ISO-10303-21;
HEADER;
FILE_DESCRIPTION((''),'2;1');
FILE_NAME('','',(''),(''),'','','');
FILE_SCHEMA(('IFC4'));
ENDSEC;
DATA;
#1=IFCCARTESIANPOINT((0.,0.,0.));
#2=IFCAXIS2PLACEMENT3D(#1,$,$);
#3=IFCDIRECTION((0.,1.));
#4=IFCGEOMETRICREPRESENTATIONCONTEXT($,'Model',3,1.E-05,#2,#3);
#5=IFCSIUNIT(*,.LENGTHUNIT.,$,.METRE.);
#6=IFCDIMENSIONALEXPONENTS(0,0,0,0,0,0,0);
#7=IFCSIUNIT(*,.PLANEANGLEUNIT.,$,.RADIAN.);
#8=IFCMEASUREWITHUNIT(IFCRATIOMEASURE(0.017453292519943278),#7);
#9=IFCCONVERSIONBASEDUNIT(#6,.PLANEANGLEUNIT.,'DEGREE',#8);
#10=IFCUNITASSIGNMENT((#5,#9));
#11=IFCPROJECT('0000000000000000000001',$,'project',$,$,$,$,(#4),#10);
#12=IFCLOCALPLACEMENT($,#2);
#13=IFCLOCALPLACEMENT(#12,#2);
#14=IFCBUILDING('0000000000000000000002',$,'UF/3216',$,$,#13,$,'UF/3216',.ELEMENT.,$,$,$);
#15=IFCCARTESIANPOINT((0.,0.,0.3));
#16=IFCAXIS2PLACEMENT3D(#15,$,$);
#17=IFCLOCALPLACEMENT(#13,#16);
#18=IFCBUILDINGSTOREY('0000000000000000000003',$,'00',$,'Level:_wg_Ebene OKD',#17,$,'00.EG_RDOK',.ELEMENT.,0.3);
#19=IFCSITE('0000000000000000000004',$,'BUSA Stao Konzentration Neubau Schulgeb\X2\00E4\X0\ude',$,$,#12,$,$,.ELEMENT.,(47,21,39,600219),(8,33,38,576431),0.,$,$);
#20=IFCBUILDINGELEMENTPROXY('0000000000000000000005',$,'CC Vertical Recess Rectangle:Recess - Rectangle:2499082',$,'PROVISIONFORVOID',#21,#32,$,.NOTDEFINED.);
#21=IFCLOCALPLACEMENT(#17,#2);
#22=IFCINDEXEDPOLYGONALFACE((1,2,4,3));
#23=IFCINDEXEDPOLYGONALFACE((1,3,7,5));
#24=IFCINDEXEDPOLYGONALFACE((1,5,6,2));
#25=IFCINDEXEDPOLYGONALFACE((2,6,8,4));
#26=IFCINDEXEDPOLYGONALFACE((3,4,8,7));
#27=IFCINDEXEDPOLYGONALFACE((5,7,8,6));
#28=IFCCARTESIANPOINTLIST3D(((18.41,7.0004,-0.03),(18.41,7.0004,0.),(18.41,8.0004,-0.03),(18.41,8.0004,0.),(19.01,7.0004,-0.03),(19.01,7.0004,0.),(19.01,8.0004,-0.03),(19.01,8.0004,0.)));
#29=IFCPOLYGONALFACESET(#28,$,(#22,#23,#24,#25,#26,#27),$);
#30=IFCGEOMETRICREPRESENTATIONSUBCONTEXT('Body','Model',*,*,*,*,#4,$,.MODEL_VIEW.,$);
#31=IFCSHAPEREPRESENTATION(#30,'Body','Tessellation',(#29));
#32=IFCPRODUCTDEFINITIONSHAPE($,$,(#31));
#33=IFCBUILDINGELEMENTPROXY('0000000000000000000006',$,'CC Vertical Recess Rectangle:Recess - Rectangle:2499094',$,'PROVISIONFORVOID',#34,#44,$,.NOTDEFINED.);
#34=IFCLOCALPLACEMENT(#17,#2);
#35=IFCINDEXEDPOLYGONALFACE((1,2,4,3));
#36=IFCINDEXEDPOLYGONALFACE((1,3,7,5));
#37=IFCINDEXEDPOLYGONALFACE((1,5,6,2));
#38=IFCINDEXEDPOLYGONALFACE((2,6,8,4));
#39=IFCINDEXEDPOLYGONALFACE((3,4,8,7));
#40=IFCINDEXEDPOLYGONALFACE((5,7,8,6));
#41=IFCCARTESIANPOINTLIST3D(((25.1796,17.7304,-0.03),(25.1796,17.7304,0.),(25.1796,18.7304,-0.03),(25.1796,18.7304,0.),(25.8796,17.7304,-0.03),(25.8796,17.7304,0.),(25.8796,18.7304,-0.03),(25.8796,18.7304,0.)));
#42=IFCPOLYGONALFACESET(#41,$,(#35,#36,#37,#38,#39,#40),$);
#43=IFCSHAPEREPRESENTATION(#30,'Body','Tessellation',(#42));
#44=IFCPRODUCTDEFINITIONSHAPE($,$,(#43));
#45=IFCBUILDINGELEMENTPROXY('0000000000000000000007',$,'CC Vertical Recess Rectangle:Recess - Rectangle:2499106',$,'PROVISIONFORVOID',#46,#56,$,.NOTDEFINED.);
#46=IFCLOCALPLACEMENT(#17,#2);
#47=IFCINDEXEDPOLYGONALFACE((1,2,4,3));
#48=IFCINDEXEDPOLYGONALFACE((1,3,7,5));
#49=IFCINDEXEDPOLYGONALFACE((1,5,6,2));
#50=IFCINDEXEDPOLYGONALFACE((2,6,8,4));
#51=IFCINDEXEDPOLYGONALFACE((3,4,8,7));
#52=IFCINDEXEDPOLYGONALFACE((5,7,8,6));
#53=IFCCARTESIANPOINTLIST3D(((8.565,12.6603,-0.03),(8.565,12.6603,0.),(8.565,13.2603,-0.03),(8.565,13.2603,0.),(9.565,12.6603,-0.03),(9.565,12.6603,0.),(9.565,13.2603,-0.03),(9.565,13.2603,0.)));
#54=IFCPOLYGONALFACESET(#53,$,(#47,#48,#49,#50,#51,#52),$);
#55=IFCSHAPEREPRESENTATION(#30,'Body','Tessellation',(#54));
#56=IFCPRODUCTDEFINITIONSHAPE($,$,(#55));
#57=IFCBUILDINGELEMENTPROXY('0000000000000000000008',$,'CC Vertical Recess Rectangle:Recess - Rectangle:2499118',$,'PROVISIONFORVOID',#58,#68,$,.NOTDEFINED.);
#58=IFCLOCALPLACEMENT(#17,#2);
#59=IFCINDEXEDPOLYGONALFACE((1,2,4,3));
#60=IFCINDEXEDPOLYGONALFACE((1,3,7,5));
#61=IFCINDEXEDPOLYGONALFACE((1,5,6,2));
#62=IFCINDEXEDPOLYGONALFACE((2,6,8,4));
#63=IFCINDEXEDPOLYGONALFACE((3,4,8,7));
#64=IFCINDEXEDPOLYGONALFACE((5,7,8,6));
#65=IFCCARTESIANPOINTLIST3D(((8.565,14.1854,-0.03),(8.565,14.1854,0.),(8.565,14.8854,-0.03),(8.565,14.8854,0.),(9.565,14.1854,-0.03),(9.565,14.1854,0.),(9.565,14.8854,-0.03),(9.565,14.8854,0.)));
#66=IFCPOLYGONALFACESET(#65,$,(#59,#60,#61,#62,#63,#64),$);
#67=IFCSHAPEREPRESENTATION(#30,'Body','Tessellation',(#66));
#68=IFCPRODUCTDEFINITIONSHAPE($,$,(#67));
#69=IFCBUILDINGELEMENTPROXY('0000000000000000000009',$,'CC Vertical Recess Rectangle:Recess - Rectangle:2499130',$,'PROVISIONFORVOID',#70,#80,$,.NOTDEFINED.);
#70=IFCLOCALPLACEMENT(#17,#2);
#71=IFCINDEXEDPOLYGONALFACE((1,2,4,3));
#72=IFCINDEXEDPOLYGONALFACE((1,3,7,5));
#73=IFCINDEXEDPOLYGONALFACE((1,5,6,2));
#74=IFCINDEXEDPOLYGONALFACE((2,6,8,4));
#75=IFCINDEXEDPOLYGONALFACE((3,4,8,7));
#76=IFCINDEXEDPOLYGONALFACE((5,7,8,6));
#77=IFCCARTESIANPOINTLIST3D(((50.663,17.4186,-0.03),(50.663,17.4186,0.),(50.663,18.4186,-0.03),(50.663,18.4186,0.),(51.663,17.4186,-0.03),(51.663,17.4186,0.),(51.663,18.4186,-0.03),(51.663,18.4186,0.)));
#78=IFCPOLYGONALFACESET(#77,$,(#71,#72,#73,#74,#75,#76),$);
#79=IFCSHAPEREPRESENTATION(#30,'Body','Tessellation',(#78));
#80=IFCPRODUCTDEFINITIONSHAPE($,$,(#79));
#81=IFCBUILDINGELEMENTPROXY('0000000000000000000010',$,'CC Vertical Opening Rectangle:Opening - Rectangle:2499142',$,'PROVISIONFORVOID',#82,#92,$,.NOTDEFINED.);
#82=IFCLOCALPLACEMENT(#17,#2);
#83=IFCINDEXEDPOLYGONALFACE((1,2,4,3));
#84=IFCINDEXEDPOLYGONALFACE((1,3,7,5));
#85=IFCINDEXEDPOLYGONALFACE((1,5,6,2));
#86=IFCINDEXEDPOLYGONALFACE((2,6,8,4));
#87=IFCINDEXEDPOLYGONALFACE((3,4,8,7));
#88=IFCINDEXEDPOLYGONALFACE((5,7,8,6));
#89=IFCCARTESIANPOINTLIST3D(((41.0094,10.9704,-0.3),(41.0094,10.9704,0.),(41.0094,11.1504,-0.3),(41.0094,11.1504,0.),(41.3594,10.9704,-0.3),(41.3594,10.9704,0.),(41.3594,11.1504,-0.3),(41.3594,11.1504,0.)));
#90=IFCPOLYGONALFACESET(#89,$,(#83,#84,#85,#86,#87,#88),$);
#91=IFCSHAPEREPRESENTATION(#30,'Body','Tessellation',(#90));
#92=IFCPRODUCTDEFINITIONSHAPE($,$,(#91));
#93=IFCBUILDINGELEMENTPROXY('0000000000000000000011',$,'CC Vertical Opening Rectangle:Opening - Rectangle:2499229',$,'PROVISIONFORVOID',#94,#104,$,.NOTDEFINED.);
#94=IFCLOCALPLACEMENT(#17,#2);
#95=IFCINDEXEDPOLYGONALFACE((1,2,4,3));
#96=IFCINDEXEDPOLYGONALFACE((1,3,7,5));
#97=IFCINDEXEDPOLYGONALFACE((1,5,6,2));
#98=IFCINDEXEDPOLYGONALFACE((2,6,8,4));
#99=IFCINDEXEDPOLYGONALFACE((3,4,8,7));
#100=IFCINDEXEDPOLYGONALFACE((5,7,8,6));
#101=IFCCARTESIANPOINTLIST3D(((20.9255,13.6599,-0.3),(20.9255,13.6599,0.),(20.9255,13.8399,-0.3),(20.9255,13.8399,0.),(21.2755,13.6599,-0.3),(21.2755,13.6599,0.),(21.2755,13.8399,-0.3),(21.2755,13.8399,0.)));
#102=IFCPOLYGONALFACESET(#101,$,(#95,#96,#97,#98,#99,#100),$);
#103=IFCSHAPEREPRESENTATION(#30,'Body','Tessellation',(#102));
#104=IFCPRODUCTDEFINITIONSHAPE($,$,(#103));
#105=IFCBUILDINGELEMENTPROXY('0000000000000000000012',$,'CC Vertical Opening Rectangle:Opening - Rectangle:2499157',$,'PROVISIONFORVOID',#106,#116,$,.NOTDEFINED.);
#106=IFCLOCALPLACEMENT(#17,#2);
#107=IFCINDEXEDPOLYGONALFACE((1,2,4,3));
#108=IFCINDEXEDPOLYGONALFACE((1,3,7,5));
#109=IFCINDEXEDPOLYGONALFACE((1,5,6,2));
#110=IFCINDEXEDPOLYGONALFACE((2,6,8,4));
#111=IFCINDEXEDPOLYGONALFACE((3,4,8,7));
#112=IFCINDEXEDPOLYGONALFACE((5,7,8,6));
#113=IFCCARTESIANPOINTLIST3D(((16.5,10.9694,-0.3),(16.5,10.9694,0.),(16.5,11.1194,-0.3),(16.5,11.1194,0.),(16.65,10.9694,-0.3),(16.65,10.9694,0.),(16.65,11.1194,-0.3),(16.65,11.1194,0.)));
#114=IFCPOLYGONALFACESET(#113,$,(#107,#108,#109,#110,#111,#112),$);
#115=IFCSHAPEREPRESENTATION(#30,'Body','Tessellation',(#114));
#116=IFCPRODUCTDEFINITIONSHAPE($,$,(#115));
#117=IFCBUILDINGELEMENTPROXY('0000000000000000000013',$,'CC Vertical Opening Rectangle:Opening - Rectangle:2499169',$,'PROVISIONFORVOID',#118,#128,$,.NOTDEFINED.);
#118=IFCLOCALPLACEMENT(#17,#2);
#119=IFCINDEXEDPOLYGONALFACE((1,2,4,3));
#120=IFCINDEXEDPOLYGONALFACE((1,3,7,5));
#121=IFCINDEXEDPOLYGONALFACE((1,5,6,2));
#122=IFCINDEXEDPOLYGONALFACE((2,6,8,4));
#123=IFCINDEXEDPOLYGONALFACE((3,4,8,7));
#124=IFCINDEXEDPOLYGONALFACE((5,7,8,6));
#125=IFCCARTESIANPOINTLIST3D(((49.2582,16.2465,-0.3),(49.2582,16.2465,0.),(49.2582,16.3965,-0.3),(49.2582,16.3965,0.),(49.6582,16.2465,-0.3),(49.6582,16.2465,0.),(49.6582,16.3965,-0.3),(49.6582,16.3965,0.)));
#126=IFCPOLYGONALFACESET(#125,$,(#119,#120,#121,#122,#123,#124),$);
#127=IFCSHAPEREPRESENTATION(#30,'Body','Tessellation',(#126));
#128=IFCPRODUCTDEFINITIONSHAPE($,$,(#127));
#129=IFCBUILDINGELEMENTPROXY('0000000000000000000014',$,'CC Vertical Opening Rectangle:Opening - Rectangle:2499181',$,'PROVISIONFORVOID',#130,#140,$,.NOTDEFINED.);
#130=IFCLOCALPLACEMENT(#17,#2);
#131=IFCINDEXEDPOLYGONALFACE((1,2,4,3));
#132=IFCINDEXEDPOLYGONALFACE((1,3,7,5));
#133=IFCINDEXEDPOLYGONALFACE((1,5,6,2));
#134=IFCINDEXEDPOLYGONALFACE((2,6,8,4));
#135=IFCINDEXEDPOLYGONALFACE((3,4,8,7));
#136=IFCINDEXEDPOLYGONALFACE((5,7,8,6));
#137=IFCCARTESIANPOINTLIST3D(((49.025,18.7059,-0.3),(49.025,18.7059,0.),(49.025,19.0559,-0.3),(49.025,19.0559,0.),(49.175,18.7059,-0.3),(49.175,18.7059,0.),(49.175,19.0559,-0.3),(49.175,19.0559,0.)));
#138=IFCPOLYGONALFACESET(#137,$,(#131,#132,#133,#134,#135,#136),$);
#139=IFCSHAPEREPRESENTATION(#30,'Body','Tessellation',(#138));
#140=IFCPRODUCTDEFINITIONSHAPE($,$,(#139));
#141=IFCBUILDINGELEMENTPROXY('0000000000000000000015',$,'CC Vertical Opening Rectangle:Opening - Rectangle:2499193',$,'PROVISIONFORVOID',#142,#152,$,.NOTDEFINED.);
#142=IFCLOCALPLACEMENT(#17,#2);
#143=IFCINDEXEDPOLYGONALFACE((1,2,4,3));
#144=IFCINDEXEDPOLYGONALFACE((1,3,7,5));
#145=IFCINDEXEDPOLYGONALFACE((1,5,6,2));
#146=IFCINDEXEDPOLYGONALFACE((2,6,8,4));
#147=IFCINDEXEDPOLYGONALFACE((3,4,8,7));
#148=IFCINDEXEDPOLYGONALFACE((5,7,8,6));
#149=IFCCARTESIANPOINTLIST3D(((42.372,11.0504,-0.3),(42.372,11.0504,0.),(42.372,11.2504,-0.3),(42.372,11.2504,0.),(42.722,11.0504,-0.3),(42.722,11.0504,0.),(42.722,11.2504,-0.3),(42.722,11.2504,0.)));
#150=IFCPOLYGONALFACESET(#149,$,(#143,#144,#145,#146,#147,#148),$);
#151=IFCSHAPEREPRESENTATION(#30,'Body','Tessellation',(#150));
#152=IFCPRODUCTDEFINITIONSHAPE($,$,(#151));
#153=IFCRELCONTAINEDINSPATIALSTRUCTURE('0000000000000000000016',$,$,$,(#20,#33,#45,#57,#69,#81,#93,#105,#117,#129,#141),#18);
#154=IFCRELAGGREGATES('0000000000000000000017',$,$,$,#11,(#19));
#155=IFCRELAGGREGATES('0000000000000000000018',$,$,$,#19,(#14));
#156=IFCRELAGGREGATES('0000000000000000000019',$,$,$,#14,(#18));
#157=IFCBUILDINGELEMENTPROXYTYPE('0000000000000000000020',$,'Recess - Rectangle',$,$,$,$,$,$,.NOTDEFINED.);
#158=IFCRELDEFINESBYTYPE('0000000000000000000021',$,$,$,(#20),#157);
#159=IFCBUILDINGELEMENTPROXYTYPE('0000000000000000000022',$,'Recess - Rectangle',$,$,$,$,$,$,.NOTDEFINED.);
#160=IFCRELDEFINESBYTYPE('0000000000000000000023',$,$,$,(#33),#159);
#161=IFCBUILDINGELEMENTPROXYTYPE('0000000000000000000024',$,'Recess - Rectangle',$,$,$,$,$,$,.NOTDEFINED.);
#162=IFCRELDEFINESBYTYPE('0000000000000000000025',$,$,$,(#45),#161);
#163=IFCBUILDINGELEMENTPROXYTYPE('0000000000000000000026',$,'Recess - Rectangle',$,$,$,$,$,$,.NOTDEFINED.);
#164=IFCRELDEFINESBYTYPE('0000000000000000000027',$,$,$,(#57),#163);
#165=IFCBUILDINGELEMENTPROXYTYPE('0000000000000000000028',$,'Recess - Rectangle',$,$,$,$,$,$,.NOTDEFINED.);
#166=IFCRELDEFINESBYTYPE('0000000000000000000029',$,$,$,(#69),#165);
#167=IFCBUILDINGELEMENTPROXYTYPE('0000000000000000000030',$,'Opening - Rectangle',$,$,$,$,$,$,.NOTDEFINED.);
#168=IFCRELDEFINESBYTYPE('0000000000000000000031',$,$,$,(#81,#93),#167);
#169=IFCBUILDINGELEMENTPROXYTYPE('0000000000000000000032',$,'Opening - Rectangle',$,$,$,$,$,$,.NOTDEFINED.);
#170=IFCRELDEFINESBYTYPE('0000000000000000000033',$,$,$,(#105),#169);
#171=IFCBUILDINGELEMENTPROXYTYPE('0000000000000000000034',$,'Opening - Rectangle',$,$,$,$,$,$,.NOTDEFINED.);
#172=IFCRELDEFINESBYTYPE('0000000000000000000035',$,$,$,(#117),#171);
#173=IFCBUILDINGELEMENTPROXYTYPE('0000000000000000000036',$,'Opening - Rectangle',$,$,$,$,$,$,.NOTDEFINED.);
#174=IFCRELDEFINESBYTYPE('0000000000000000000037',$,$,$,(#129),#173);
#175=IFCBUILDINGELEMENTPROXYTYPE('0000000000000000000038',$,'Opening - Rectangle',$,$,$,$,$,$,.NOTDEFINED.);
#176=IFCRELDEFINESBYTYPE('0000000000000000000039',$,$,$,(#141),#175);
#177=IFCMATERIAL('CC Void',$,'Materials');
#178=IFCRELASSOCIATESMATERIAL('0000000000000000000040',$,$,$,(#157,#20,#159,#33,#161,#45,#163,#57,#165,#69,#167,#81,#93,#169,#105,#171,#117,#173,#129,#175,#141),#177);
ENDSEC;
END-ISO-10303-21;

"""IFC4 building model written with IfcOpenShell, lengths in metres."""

from ifc_helpers import new_model, entity, si_unit, converted_unit, direction, frame, origin, place, context, subcontext, project, spatial, indexed_curve, outline, extrude, source, transform, mapped, material, type_object, type_shapes, element, save


model = new_model("IFC4")

# Units and contexts
model_context = context("Model", 3, precision=1e-05, world=origin(), true_north=direction((0.0, 1.0)))
body_context = subcontext(model_context, "Body", "Model", "MODEL_VIEW")
ifc_project = project(units=[si_unit("LENGTHUNIT", "METRE"), converted_unit("PLANEANGLEUNIT", "DEGREE", entity("IfcRatioMeasure", 0.017453292519943278), si_unit("PLANEANGLEUNIT", "RADIAN"), dimensions=[0, 0, 0, 0, 0, 0, 0])], contexts=[model_context])

# Site, building, storey
site_placement = place(None, origin())
site = spatial("IfcSite", under=ifc_project, at=site_placement, Name="BUSA Stao Konzentration Neubau Schulgebäude", CompositionType="ELEMENT", RefLatitude=(47, 21, 39, 600219), RefLongitude=(8, 33, 38, 576431), RefElevation=0.0)
building_placement = place(site_placement, origin())
building = spatial("IfcBuilding", under=site, at=building_placement, Name="UF/3216", LongName="UF/3216", CompositionType="ELEMENT")
storey_placement = place(building_placement, frame((0.0, 0.0, 0.3)))
storey = spatial("IfcBuildingStorey", under=building, at=storey_placement, Name="00", ObjectType="Level:_wg_Ebene OKD", LongName="00.EG_RDOK", CompositionType="ELEMENT", Elevation=0.3)

# Building element proxies
ifc_material_1 = material(Name="CC Void", Category="Materials")
building_element_proxy_type_1 = type_object("IfcBuildingElementProxyType", Name="Recess - Rectangle", PredefinedType="NOTDEFINED", material=ifc_material_1)
shared_shape_1 = source(origin(), body_context, "Body", "SweptSolid", [
    extrude(outline(indexed_curve([(-0.3, -0.5), (0.3, -0.5), (0.3, 0.5), (-0.3, 0.5), (-0.3, -0.5)], self_intersect=False)), frame((0.0, 0.0, 0.27), z_axis=(0.0, 0.0, 1.0), x_axis=(0.0, 1.0, 0.0)), (0.0, 0.0, 1.0), 0.03),
])
type_shapes(building_element_proxy_type_1, [shared_shape_1])
proxy_1_placement = place(storey_placement, frame((18.71, 7.5004, -0.3), z_axis=(0.0, 0.0, 1.0), x_axis=(0.0, -1.0, 0.0)))
element("IfcBuildingElementProxy", 1, at=proxy_1_placement, inside=storey, type_object=building_element_proxy_type_1, material=ifc_material_1, Name="CC Vertical Recess Rectangle:Recess - Rectangle:2499082", ObjectType="PROVISIONFORVOID", PredefinedType="NOTDEFINED", context=body_context, shape_type="MappedRepresentation", body=[
    mapped(shared_shape_1, transform((0.0, 0.0, 0.0), scale=1.0)),
])
building_element_proxy_type_2 = type_object("IfcBuildingElementProxyType", Name="Recess - Rectangle", PredefinedType="NOTDEFINED", material=ifc_material_1)
shared_shape_2 = source(origin(), body_context, "Body", "SweptSolid", [
    extrude(outline(indexed_curve([(-0.35, -0.5), (0.35, -0.5), (0.35, 0.5), (-0.35, 0.5), (-0.35, -0.5)], self_intersect=False)), frame((0.0, 0.0, 0.27), z_axis=(0.0, 0.0, 1.0), x_axis=(0.0, 1.0, 0.0)), (0.0, 0.0, 1.0), 0.03),
])
type_shapes(building_element_proxy_type_2, [shared_shape_2])
proxy_2_placement = place(storey_placement, frame((25.5296, 18.2304, -0.3), z_axis=(0.0, 0.0, 1.0), x_axis=(0.0, -1.0, 0.0)))
element("IfcBuildingElementProxy", 2, at=proxy_2_placement, inside=storey, type_object=building_element_proxy_type_2, material=ifc_material_1, Name="CC Vertical Recess Rectangle:Recess - Rectangle:2499094", ObjectType="PROVISIONFORVOID", PredefinedType="NOTDEFINED", context=body_context, shape_type="MappedRepresentation", body=[
    mapped(shared_shape_2, transform((0.0, 0.0, 0.0), scale=1.0)),
])
building_element_proxy_type_3 = type_object("IfcBuildingElementProxyType", Name="Recess - Rectangle", PredefinedType="NOTDEFINED", material=ifc_material_1)
shared_shape_3 = source(origin(), body_context, "Body", "SweptSolid", [
    extrude(outline(indexed_curve([(-0.5, -0.3), (0.5, -0.3), (0.5, 0.3), (-0.5, 0.3), (-0.5, -0.3)], self_intersect=False)), frame((0.0, 0.0, 0.27), z_axis=(0.0, 0.0, 1.0), x_axis=(0.0, 1.0, 0.0)), (0.0, 0.0, 1.0), 0.03),
])
type_shapes(building_element_proxy_type_3, [shared_shape_3])
proxy_3_placement = place(storey_placement, frame((9.065, 12.9603, -0.3), z_axis=(0.0, 0.0, 1.0), x_axis=(0.0, -1.0, 0.0)))
element("IfcBuildingElementProxy", 3, at=proxy_3_placement, inside=storey, type_object=building_element_proxy_type_3, material=ifc_material_1, Name="CC Vertical Recess Rectangle:Recess - Rectangle:2499106", ObjectType="PROVISIONFORVOID", PredefinedType="NOTDEFINED", context=body_context, shape_type="MappedRepresentation", body=[
    mapped(shared_shape_3, transform((0.0, 0.0, 0.0), scale=1.0)),
])
building_element_proxy_type_4 = type_object("IfcBuildingElementProxyType", Name="Recess - Rectangle", PredefinedType="NOTDEFINED", material=ifc_material_1)
shared_shape_4 = source(origin(), body_context, "Body", "SweptSolid", [
    extrude(outline(indexed_curve([(-0.5, -0.35), (0.5, -0.35), (0.5, 0.35), (-0.5, 0.35), (-0.5, -0.35)], self_intersect=False)), frame((0.0, 0.0, 0.27), z_axis=(0.0, 0.0, 1.0), x_axis=(0.0, 1.0, 0.0)), (0.0, 0.0, 1.0), 0.03),
])
type_shapes(building_element_proxy_type_4, [shared_shape_4])
proxy_4_placement = place(storey_placement, frame((9.065, 14.5354, -0.3), z_axis=(0.0, 0.0, 1.0), x_axis=(0.0, -1.0, 0.0)))
element("IfcBuildingElementProxy", 4, at=proxy_4_placement, inside=storey, type_object=building_element_proxy_type_4, material=ifc_material_1, Name="CC Vertical Recess Rectangle:Recess - Rectangle:2499118", ObjectType="PROVISIONFORVOID", PredefinedType="NOTDEFINED", context=body_context, shape_type="MappedRepresentation", body=[
    mapped(shared_shape_4, transform((0.0, 0.0, 0.0), scale=1.0)),
])
building_element_proxy_type_5 = type_object("IfcBuildingElementProxyType", Name="Recess - Rectangle", PredefinedType="NOTDEFINED", material=ifc_material_1)
shared_shape_5 = source(origin(), body_context, "Body", "SweptSolid", [
    extrude(outline(indexed_curve([(-0.5, -0.5), (0.5, -0.5), (0.5, 0.5), (-0.5, 0.5), (-0.5, -0.5)], self_intersect=False)), frame((0.0, 0.0, 0.27), z_axis=(0.0, 0.0, 1.0), x_axis=(0.0, 1.0, 0.0)), (0.0, 0.0, 1.0), 0.03),
])
type_shapes(building_element_proxy_type_5, [shared_shape_5])
proxy_5_placement = place(storey_placement, frame((51.163, 17.9186, -0.3), z_axis=(0.0, 0.0, 1.0), x_axis=(0.0, -1.0, 0.0)))
element("IfcBuildingElementProxy", 5, at=proxy_5_placement, inside=storey, type_object=building_element_proxy_type_5, material=ifc_material_1, Name="CC Vertical Recess Rectangle:Recess - Rectangle:2499130", ObjectType="PROVISIONFORVOID", PredefinedType="NOTDEFINED", context=body_context, shape_type="MappedRepresentation", body=[
    mapped(shared_shape_5, transform((0.0, 0.0, 0.0), scale=1.0)),
])
building_element_proxy_type_6 = type_object("IfcBuildingElementProxyType", Name="Opening - Rectangle", PredefinedType="NOTDEFINED", material=ifc_material_1)
shared_shape_6 = source(origin(), body_context, "Body", "SweptSolid", [
    extrude(outline(indexed_curve([(-0.175, -0.09), (0.175, -0.09), (0.175, 0.09), (-0.175, 0.09), (-0.175, -0.09)], self_intersect=False)), frame((0.0, 0.0, 0.0), z_axis=(0.0, 0.0, 1.0), x_axis=(0.0, 1.0, 0.0)), (0.0, 0.0, 1.0), 0.3),
])
type_shapes(building_element_proxy_type_6, [shared_shape_6])
for number, where, z_axis, x_axis, name in (
    (6, (41.1844, 11.0604, -0.3), (0.0, 0.0, 1.0), (0.0, -1.0, 0.0), "CC Vertical Opening Rectangle:Opening - Rectangle:2499142"),
    (7, (21.1005, 13.7499, -0.3), (0.0, 0.0, 1.0), (0.0, -1.0, 0.0), "CC Vertical Opening Rectangle:Opening - Rectangle:2499229"),
):
    element("IfcBuildingElementProxy", number, at=place(storey_placement, frame(where, z_axis=z_axis, x_axis=x_axis)), inside=storey, type_object=building_element_proxy_type_6, material=ifc_material_1, Name=name, ObjectType="PROVISIONFORVOID", PredefinedType="NOTDEFINED", context=body_context, shape_type="MappedRepresentation", body=[
        mapped(shared_shape_6, transform((0.0, 0.0, 0.0), scale=1.0)),
    ])
building_element_proxy_type_7 = type_object("IfcBuildingElementProxyType", Name="Opening - Rectangle", PredefinedType="NOTDEFINED", material=ifc_material_1)
shared_shape_7 = source(origin(), body_context, "Body", "SweptSolid", [
    extrude(outline(indexed_curve([(-0.075, -0.075), (0.075, -0.075), (0.075, 0.075), (-0.075, 0.075), (-0.075, -0.075)], self_intersect=False)), frame((0.0, 0.0, 0.0), z_axis=(0.0, 0.0, 1.0), x_axis=(0.0, 1.0, 0.0)), (0.0, 0.0, 1.0), 0.3),
])
type_shapes(building_element_proxy_type_7, [shared_shape_7])
proxy_6_placement = place(storey_placement, frame((16.575, 11.0444, -0.3), z_axis=(0.0, 0.0, 1.0), x_axis=(0.0, -1.0, 0.0)))
element("IfcBuildingElementProxy", 8, at=proxy_6_placement, inside=storey, type_object=building_element_proxy_type_7, material=ifc_material_1, Name="CC Vertical Opening Rectangle:Opening - Rectangle:2499157", ObjectType="PROVISIONFORVOID", PredefinedType="NOTDEFINED", context=body_context, shape_type="MappedRepresentation", body=[
    mapped(shared_shape_7, transform((0.0, 0.0, 0.0), scale=1.0)),
])
building_element_proxy_type_8 = type_object("IfcBuildingElementProxyType", Name="Opening - Rectangle", PredefinedType="NOTDEFINED", material=ifc_material_1)
shared_shape_8 = source(origin(), body_context, "Body", "SweptSolid", [
    extrude(outline(indexed_curve([(-0.2, -0.075), (0.2, -0.075), (0.2, 0.075), (-0.2, 0.075), (-0.2, -0.075)], self_intersect=False)), frame((0.0, 0.0, 0.0), z_axis=(0.0, 0.0, 1.0), x_axis=(0.0, 1.0, 0.0)), (0.0, 0.0, 1.0), 0.3),
])
type_shapes(building_element_proxy_type_8, [shared_shape_8])
proxy_7_placement = place(storey_placement, frame((49.4582, 16.3215, -0.3), z_axis=(0.0, 0.0, 1.0), x_axis=(0.0, -1.0, 0.0)))
element("IfcBuildingElementProxy", 9, at=proxy_7_placement, inside=storey, type_object=building_element_proxy_type_8, material=ifc_material_1, Name="CC Vertical Opening Rectangle:Opening - Rectangle:2499169", ObjectType="PROVISIONFORVOID", PredefinedType="NOTDEFINED", context=body_context, shape_type="MappedRepresentation", body=[
    mapped(shared_shape_8, transform((0.0, 0.0, 0.0), scale=1.0)),
])
building_element_proxy_type_9 = type_object("IfcBuildingElementProxyType", Name="Opening - Rectangle", PredefinedType="NOTDEFINED", material=ifc_material_1)
shared_shape_9 = source(origin(), body_context, "Body", "SweptSolid", [
    extrude(outline(indexed_curve([(-0.075, -0.175), (0.075, -0.175), (0.075, 0.175), (-0.075, 0.175), (-0.075, -0.175)], self_intersect=False)), frame((0.0, 0.0, 0.0), z_axis=(0.0, 0.0, 1.0), x_axis=(0.0, 1.0, 0.0)), (0.0, 0.0, 1.0), 0.3),
])
type_shapes(building_element_proxy_type_9, [shared_shape_9])
proxy_8_placement = place(storey_placement, frame((49.1, 18.8809, -0.3), z_axis=(0.0, 0.0, 1.0), x_axis=(0.0, -1.0, 0.0)))
element("IfcBuildingElementProxy", 10, at=proxy_8_placement, inside=storey, type_object=building_element_proxy_type_9, material=ifc_material_1, Name="CC Vertical Opening Rectangle:Opening - Rectangle:2499181", ObjectType="PROVISIONFORVOID", PredefinedType="NOTDEFINED", context=body_context, shape_type="MappedRepresentation", body=[
    mapped(shared_shape_9, transform((0.0, 0.0, 0.0), scale=1.0)),
])
building_element_proxy_type_10 = type_object("IfcBuildingElementProxyType", Name="Opening - Rectangle", PredefinedType="NOTDEFINED", material=ifc_material_1)
shared_shape_10 = source(origin(), body_context, "Body", "SweptSolid", [
    extrude(outline(indexed_curve([(-0.175, -0.1), (0.175, -0.1), (0.175, 0.1), (-0.175, 0.1), (-0.175, -0.1)], self_intersect=False)), frame((0.0, 0.0, 0.0), z_axis=(0.0, 0.0, 1.0), x_axis=(0.0, 1.0, 0.0)), (0.0, 0.0, 1.0), 0.3),
])
type_shapes(building_element_proxy_type_10, [shared_shape_10])
for number, where, z_axis, x_axis, name in (
    (11, (42.547, 11.1504, -0.3), (0.0, 0.0, 1.0), (0.0, -1.0, 0.0), "CC Vertical Opening Rectangle:Opening - Rectangle:2499193"),
):
    element("IfcBuildingElementProxy", number, at=place(storey_placement, frame(where, z_axis=z_axis, x_axis=x_axis)), inside=storey, type_object=building_element_proxy_type_10, material=ifc_material_1, Name=name, ObjectType="PROVISIONFORVOID", PredefinedType="NOTDEFINED", context=body_context, shape_type="MappedRepresentation", body=[
        mapped(shared_shape_10, transform((0.0, 0.0, 0.0), scale=1.0)),
    ])

save(model, "model.ifc")
